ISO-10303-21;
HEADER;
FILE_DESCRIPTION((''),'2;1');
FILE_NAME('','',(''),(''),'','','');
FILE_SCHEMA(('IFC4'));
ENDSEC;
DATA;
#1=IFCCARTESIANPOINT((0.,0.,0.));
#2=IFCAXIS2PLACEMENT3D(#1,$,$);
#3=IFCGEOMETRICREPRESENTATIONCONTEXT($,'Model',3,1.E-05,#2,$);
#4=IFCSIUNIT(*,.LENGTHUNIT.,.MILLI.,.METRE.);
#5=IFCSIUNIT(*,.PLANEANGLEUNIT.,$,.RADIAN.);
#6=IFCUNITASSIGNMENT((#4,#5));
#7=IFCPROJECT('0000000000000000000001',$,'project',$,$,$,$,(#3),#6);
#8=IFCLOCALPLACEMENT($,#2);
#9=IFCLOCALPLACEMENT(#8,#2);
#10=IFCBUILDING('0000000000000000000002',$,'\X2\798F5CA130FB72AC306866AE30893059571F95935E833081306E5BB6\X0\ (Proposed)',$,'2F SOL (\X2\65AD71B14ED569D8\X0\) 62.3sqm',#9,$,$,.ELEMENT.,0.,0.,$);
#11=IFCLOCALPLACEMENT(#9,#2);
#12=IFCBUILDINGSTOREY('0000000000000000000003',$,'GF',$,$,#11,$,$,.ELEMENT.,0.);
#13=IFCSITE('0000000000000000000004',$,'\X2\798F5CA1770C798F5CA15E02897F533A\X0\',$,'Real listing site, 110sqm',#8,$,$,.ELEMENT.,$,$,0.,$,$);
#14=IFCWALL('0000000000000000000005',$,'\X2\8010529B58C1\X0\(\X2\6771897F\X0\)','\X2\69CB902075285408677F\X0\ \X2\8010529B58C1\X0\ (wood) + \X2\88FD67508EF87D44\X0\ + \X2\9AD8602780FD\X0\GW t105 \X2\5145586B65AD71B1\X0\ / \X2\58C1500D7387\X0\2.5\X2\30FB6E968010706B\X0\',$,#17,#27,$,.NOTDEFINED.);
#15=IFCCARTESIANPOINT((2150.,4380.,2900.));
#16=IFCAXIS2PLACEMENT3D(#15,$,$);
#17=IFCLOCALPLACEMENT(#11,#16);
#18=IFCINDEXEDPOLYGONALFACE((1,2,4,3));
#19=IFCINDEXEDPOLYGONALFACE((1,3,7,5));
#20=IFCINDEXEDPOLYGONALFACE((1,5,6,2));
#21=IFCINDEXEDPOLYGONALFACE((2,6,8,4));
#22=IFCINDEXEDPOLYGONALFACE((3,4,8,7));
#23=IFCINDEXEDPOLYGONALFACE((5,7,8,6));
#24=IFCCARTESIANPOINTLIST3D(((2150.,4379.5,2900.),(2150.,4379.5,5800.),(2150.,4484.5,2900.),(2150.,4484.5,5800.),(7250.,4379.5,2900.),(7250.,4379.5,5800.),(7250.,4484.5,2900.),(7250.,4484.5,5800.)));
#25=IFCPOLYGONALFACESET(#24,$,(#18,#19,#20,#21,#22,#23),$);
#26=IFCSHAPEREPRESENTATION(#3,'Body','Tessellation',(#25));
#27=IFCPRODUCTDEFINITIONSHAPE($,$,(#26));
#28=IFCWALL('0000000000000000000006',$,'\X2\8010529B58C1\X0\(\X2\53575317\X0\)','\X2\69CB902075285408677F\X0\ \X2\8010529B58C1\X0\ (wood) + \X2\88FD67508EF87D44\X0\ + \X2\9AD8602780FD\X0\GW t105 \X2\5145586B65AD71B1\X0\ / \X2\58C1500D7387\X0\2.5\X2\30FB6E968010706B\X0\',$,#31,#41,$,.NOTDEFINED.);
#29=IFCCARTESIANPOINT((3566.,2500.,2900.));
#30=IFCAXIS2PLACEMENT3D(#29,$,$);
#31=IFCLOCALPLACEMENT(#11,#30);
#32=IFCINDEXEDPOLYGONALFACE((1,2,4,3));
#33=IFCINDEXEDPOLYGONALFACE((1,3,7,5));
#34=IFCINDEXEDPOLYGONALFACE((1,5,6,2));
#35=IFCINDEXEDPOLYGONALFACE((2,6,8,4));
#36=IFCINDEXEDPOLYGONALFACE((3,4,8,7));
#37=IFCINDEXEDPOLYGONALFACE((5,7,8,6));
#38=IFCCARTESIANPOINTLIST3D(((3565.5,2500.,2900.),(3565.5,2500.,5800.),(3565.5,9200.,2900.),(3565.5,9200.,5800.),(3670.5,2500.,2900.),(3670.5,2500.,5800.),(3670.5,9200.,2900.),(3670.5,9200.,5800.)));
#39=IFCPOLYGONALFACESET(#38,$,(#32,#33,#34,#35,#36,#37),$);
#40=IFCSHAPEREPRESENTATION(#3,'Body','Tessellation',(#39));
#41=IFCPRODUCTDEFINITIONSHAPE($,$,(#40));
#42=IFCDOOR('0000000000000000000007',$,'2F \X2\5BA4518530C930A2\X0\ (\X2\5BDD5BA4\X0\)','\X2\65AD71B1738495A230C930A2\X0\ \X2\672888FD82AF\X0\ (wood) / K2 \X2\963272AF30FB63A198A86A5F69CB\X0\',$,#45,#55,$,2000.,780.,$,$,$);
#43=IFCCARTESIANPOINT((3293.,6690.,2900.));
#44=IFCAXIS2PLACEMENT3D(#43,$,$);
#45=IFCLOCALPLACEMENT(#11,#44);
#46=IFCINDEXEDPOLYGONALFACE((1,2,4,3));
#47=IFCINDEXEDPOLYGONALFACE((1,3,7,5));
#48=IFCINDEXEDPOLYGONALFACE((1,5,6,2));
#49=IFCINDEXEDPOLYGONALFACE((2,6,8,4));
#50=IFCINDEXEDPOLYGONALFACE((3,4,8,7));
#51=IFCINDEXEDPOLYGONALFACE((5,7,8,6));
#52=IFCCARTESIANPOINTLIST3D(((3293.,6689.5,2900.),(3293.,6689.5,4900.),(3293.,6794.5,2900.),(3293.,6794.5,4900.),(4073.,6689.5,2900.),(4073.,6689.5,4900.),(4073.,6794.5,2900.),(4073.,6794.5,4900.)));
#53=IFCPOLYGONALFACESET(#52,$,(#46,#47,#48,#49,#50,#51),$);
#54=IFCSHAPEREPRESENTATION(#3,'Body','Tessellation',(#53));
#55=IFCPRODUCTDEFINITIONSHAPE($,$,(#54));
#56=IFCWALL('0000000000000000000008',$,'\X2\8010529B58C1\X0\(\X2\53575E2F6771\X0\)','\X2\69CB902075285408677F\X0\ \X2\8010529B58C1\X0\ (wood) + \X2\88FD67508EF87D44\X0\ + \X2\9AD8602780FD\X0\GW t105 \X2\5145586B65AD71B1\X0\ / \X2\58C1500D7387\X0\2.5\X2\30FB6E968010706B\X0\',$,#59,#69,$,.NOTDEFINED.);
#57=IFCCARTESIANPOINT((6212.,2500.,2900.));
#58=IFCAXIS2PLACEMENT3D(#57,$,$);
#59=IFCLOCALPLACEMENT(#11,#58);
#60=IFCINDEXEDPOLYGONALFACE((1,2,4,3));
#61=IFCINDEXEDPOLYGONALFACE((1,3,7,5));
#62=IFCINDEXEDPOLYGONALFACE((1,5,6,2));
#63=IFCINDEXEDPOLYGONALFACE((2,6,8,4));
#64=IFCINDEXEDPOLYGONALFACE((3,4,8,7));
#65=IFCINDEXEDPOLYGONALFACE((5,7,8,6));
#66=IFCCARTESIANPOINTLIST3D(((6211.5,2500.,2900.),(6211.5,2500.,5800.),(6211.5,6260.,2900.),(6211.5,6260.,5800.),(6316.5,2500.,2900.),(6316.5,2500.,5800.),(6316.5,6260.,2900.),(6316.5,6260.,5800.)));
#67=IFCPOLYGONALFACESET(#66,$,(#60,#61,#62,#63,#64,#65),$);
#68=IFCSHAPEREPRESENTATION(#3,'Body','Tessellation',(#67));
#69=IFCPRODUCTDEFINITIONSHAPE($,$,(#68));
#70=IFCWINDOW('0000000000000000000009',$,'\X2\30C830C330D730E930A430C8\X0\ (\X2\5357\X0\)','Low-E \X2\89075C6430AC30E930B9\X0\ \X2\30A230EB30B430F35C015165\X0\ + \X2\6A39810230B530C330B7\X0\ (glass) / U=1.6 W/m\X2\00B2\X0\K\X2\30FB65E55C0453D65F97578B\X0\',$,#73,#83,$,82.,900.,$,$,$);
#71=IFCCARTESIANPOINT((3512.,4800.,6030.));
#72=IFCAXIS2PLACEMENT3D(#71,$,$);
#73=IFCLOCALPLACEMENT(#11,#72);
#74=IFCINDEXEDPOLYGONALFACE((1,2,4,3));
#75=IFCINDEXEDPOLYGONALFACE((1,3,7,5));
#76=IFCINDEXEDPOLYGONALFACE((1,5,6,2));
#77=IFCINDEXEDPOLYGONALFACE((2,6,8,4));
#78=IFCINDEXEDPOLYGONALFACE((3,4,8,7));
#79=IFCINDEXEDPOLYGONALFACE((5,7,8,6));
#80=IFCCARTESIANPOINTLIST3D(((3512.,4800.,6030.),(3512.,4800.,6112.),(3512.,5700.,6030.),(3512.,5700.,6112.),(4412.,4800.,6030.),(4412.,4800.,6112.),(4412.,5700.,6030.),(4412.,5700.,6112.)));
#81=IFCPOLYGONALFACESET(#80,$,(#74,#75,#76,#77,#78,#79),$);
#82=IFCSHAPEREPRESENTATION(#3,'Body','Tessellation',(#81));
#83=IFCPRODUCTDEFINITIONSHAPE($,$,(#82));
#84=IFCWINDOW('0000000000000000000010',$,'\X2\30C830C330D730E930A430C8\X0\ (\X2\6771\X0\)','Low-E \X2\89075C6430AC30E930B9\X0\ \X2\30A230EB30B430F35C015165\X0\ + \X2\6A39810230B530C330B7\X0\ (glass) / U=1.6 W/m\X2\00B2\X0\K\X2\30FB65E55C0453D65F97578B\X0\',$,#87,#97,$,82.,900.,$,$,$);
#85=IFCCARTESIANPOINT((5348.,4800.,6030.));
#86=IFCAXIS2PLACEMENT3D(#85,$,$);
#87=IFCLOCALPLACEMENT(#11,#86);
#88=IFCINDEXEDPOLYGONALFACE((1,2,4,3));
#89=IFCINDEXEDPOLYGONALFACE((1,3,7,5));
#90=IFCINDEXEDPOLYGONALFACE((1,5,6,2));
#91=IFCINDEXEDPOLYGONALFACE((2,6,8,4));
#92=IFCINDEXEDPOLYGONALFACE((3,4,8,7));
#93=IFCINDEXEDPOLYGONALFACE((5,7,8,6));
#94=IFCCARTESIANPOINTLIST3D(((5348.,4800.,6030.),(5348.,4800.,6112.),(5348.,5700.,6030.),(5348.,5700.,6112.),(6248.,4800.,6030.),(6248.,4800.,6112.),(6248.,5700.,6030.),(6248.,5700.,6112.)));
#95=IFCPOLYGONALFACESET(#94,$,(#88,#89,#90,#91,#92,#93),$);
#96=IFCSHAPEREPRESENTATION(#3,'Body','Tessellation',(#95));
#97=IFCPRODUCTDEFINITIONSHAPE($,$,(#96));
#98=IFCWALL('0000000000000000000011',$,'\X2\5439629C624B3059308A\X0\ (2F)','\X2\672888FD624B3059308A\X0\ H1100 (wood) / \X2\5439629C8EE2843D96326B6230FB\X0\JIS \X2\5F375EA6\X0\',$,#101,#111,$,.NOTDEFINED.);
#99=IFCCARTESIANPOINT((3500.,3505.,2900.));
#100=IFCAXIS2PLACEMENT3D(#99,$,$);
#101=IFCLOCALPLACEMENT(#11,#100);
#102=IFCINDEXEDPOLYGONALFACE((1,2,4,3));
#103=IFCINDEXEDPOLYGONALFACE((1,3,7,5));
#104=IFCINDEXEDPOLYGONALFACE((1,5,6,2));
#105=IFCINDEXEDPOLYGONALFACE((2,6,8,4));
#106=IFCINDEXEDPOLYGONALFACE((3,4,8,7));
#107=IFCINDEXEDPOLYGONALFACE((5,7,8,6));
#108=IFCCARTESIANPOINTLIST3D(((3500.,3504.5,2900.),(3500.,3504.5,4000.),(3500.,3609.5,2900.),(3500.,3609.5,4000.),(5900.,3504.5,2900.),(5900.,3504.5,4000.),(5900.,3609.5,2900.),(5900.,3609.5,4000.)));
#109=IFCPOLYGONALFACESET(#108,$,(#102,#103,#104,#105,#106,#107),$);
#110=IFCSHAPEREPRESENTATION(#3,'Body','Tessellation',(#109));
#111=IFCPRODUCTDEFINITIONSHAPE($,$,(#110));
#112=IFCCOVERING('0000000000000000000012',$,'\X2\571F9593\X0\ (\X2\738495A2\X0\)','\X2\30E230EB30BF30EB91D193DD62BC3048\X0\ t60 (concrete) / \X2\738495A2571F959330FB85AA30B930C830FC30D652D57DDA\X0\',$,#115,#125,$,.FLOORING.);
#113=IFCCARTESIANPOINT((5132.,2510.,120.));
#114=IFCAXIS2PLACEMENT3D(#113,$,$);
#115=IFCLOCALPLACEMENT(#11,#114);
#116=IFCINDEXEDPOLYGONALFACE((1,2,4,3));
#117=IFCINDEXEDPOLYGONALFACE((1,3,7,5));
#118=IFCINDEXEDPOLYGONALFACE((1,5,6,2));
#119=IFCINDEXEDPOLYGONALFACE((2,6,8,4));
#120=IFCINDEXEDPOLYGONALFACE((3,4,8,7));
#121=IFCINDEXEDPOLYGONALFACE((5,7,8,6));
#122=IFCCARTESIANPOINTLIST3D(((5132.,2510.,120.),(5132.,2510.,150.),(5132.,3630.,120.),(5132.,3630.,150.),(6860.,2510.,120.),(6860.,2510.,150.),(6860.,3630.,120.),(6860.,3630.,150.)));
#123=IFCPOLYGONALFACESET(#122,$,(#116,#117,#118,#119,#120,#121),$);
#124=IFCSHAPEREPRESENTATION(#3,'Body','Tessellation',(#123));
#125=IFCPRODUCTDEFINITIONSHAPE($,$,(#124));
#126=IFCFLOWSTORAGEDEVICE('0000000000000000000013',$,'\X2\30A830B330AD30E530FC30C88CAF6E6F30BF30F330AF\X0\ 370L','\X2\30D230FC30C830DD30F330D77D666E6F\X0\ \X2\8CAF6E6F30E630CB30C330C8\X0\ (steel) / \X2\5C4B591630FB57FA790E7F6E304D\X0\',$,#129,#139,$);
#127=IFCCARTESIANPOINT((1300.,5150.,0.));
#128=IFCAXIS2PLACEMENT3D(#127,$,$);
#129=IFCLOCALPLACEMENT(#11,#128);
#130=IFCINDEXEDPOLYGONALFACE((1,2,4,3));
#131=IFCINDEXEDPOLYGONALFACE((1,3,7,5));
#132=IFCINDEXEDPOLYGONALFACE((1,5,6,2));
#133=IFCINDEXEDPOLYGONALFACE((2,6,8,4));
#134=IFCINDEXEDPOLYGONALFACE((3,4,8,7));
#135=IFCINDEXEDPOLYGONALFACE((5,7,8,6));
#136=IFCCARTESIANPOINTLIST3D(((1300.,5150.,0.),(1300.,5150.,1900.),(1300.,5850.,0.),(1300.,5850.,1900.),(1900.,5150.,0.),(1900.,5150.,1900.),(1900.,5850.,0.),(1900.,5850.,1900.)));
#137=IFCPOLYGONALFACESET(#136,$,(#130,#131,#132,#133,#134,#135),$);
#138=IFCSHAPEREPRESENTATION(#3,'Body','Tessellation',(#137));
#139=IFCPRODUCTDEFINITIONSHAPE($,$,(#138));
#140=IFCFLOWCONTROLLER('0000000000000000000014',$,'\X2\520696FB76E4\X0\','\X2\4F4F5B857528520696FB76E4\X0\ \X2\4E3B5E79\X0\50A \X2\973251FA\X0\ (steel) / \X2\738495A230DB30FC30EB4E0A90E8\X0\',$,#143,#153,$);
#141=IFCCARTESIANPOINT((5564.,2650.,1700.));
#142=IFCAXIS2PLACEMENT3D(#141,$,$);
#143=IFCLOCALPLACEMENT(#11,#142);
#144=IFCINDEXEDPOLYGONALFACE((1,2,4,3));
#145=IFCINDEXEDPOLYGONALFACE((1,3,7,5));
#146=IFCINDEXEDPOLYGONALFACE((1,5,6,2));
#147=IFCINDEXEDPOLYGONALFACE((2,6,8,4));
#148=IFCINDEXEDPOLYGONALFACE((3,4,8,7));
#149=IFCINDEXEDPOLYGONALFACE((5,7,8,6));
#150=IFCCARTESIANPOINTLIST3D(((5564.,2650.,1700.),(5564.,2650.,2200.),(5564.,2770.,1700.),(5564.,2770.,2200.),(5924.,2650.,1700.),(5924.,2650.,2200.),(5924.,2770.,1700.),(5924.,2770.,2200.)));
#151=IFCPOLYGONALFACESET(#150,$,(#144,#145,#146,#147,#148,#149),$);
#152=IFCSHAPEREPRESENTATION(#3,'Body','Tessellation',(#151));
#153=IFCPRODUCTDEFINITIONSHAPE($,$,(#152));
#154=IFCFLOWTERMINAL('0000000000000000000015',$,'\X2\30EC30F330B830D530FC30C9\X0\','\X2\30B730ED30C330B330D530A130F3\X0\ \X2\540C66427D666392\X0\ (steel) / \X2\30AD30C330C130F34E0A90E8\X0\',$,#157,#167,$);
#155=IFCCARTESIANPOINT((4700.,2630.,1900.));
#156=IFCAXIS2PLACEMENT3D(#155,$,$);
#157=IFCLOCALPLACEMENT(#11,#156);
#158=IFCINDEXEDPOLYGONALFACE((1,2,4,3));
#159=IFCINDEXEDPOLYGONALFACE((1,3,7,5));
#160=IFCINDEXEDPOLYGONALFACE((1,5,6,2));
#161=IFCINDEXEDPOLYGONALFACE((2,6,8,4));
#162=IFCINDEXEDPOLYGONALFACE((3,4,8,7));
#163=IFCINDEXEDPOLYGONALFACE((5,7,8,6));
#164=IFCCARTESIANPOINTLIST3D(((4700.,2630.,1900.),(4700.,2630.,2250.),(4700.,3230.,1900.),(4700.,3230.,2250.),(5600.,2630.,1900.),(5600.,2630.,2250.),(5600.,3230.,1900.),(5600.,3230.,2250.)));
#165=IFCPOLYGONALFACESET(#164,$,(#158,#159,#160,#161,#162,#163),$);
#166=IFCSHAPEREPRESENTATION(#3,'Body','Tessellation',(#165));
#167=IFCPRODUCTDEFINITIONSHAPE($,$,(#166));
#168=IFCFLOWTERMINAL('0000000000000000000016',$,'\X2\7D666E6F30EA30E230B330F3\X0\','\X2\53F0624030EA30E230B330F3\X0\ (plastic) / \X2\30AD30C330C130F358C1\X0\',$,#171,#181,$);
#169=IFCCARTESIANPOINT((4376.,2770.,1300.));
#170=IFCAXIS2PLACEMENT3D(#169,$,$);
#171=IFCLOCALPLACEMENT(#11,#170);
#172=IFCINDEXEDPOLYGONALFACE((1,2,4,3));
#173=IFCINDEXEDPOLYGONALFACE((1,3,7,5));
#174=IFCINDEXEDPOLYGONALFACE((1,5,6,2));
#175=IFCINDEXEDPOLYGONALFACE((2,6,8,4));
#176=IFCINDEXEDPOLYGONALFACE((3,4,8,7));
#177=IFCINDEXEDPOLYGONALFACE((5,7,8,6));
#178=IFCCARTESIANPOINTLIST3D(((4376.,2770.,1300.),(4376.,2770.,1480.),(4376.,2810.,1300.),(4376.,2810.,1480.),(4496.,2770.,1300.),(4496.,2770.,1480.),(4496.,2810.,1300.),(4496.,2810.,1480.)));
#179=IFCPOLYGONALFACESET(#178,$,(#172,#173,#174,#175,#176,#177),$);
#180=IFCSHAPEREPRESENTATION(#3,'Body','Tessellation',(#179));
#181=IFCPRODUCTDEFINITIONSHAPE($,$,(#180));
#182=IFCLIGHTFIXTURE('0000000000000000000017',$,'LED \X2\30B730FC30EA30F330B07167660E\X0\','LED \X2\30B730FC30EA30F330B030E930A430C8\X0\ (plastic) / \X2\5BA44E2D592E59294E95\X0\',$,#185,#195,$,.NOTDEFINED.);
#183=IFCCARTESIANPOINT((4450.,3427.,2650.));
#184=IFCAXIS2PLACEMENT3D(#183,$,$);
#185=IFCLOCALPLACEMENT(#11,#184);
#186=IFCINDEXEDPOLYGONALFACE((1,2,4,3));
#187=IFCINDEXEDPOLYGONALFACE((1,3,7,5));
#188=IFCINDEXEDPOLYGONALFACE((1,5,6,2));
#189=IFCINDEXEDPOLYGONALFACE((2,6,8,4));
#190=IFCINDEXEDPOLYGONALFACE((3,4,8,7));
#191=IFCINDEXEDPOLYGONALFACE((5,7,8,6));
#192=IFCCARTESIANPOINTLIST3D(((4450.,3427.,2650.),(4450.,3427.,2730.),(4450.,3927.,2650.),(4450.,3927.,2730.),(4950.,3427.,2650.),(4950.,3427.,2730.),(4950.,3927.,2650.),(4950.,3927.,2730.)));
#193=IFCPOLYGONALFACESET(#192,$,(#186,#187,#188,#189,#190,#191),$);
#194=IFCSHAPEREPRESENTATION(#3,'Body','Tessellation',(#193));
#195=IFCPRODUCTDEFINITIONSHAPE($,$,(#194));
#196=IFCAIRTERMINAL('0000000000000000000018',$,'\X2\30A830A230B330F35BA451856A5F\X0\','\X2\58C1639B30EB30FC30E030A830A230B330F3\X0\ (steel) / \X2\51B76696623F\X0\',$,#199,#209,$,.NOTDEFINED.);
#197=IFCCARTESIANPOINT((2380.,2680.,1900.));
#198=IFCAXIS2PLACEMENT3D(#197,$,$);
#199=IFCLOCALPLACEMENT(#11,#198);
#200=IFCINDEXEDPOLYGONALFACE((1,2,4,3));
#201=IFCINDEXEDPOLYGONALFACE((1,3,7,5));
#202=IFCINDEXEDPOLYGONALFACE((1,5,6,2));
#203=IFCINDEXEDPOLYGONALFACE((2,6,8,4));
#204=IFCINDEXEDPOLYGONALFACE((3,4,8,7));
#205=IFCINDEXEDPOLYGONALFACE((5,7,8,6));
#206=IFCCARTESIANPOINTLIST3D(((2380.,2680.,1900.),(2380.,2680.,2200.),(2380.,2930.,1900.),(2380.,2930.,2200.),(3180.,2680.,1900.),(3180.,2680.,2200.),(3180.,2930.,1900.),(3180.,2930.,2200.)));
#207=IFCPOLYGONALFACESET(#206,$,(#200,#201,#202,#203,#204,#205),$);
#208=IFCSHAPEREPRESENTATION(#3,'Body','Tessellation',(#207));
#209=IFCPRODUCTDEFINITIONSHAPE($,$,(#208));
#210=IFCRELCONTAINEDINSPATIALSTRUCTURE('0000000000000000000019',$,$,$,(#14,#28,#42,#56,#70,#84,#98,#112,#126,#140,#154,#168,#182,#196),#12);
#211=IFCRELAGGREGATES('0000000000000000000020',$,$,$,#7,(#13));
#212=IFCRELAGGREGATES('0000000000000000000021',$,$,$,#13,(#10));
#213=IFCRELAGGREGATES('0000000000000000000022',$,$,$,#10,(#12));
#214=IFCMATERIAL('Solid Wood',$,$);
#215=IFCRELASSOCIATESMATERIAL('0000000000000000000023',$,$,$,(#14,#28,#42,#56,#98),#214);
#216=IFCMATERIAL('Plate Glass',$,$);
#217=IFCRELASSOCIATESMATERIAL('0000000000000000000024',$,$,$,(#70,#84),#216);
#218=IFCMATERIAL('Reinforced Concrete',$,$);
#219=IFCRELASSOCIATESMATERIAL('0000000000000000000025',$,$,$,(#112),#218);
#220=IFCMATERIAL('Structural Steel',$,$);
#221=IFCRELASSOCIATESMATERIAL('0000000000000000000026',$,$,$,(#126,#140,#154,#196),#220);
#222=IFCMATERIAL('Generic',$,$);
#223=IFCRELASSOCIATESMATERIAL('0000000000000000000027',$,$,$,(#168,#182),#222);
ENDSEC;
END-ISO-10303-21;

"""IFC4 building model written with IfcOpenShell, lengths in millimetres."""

from ifc_helpers import new_model, si_unit, frame, frame_2d, origin, place, context, project, spatial, rectangle, extrude, material, element, fill, save


model = new_model("IFC4")

# Units and contexts
model_context = context("Model", 3, precision=1e-05, world=origin())
ifc_project = project(units=[si_unit("LENGTHUNIT", "METRE", prefix="MILLI"), si_unit("PLANEANGLEUNIT", "RADIAN")], contexts=[model_context])

# Site, building, storey
site_placement = place(None, origin())
site = spatial("IfcSite", under=ifc_project, at=site_placement, Name="福岡県福岡市西区", ObjectType="Real listing site, 110sqm", CompositionType="ELEMENT", RefElevation=0.0)
building_placement = place(site_placement, origin())
building = spatial("IfcBuilding", under=site, at=building_placement, Name="福岡・犬と暮らす土間広めの家 (Proposed)", ObjectType="2F SOL (断熱仕様) 62.3sqm", CompositionType="ELEMENT", ElevationOfRefHeight=0.0, ElevationOfTerrain=0.0)
storey_placement = place(building_placement, origin())
storey = spatial("IfcBuildingStorey", under=building, at=storey_placement, Name="GF", CompositionType="ELEMENT", Elevation=0.0)

# Shared definitions
ifc_material_1 = material(Name="Solid Wood")

# Wall
wall_1_placement = place(storey_placement, frame((2150.0, 4380.0, 2900.0)))
element("IfcWall", 1, at=wall_1_placement, inside=storey, material=ifc_material_1, Name="耐力壁(東西)", Description="構造用合板 耐力壁 (wood) + 製材軸組 + 高性能GW t105 充填断熱 / 壁倍率2.5・準耐火", PredefinedType="NOTDEFINED", context=model_context, shape_type="SweptSolid", body=[
    extrude(rectangle(XDim=5100.0, YDim=105.0, at=frame_2d((2550.0, 52.0))), frame((2150.0, 4380.0, 2900.0)), (0.0, 0.0, 1.0), 2900.0),
])

# Wall, opening, door
wall_2_placement = place(storey_placement, frame((3566.0, 2500.0, 2900.0)))
wall_2 = element("IfcWall", 2, at=wall_2_placement, inside=storey, material=ifc_material_1, Name="耐力壁(南北)", Description="構造用合板 耐力壁 (wood) + 製材軸組 + 高性能GW t105 充填断熱 / 壁倍率2.5・準耐火", PredefinedType="NOTDEFINED", context=model_context, shape_type="SweptSolid", body=[
    extrude(rectangle(XDim=105.0, YDim=6700.0, at=frame_2d((52.0, 3350.0))), frame((3566.0, 2500.0, 2900.0)), (0.0, 0.0, 1.0), 2900.0),
])
opening_placement = place(storey_placement, frame((3293.0, 6690.0, 2900.0)))
opening = element("IfcOpeningElement", 3, at=opening_placement, cuts=wall_2, PredefinedType="NOTDEFINED", context=model_context, shape_type="SweptSolid", body=[
    extrude(rectangle(XDim=780.0, YDim=105.0, at=frame_2d((390.0, 52.0))), frame((3293.0, 6690.0, 2900.0)), (0.0, 0.0, 1.0), 2000.0),
])
door_placement = place(storey_placement, frame((3293.0, 6690.0, 2900.0)))
door = element("IfcDoor", 4, at=door_placement, inside=storey, material=ifc_material_1, Name="2F 室内ドア (寝室)", Description="断熱玄関ドア 木製芯 (wood) / K2 防犯・採風機構", OverallHeight=2000.0, OverallWidth=780.0, context=model_context, shape_type="SweptSolid", body=[
    extrude(rectangle(XDim=780.0, YDim=105.0, at=frame_2d((390.0, 52.0))), frame((3293.0, 6690.0, 2900.0)), (0.0, 0.0, 1.0), 2000.0),
])
fill(opening, door)

# Wall
wall_3_placement = place(storey_placement, frame((6212.0, 2500.0, 2900.0)))
element("IfcWall", 5, at=wall_3_placement, inside=storey, material=ifc_material_1, Name="耐力壁(南帯東)", Description="構造用合板 耐力壁 (wood) + 製材軸組 + 高性能GW t105 充填断熱 / 壁倍率2.5・準耐火", PredefinedType="NOTDEFINED", context=model_context, shape_type="SweptSolid", body=[
    extrude(rectangle(XDim=105.0, YDim=3760.0, at=frame_2d((52.0, 1880.0))), frame((6212.0, 2500.0, 2900.0)), (0.0, 0.0, 1.0), 2900.0),
])

# Windows
ifc_material_2 = material(Name="Plate Glass")
window_1_placement = place(storey_placement, frame((3512.0, 4800.0, 6030.0)))
element("IfcWindow", 6, at=window_1_placement, inside=storey, material=ifc_material_2, Name="トップライト (南)", Description="Low-E 複層ガラス アルゴン封入 + 樹脂サッシ (glass) / U=1.6 W/m²K・日射取得型", OverallHeight=82.0, OverallWidth=900.0, context=model_context, shape_type="SweptSolid", body=[
    extrude(rectangle(XDim=900.0, YDim=900.0, at=frame_2d((450.0, 450.0))), frame((3512.0, 4800.0, 6030.0)), (0.0, 0.0, 1.0), 82.0),
])
window_2_placement = place(storey_placement, frame((5348.0, 4800.0, 6030.0)))
element("IfcWindow", 7, at=window_2_placement, inside=storey, material=ifc_material_2, Name="トップライト (東)", Description="Low-E 複層ガラス アルゴン封入 + 樹脂サッシ (glass) / U=1.6 W/m²K・日射取得型", OverallHeight=82.0, OverallWidth=900.0, context=model_context, shape_type="SweptSolid", body=[
    extrude(rectangle(XDim=900.0, YDim=900.0, at=frame_2d((450.0, 450.0))), frame((5348.0, 4800.0, 6030.0)), (0.0, 0.0, 1.0), 82.0),
])

# Wall
wall_4_placement = place(storey_placement, frame((3500.0, 3505.0, 2900.0)))
element("IfcWall", 8, at=wall_4_placement, inside=storey, material=ifc_material_1, Name="吹抜手すり (2F)", Description="木製手すり H1100 (wood) / 吹抜転落防止・JIS 強度", PredefinedType="NOTDEFINED", context=model_context, shape_type="SweptSolid", body=[
    extrude(rectangle(XDim=2400.0, YDim=105.0, at=frame_2d((1200.0, 52.0))), frame((3500.0, 3505.0, 2900.0)), (0.0, 0.0, 1.0), 1100.0),
])

# Covering
ifc_material_3 = material(Name="Reinforced Concrete")
covering_placement = place(storey_placement, frame((5132.0, 2510.0, 120.0)))
element("IfcCovering", 9, at=covering_placement, inside=storey, material=ifc_material_3, Name="土間 (玄関)", Description="モルタル金鏝押え t60 (concrete) / 玄関土間・薪ストーブ動線", PredefinedType="FLOORING", context=model_context, shape_type="SweptSolid", body=[
    extrude(rectangle(XDim=1728.0, YDim=1120.0, at=frame_2d((864.0, 560.0))), frame((5132.0, 2510.0, 120.0)), (0.0, 0.0, 1.0), 30.0),
])

# Flow storage device
ifc_material_4 = material(Name="Structural Steel")
flow_storage_device_placement = place(storey_placement, frame((1300.0, 5150.0, 0.0)))
element("IfcFlowStorageDevice", 10, at=flow_storage_device_placement, inside=storey, material=ifc_material_4, Name="エコキュート貯湯タンク 370L", Description="ヒートポンプ給湯 貯湯ユニット (steel) / 屋外・基礎置き", context=model_context, shape_type="SweptSolid", body=[
    extrude(rectangle(XDim=600.0, YDim=700.0, at=frame_2d((300.0, 350.0))), frame((1300.0, 5150.0, 0.0)), (0.0, 0.0, 1.0), 1900.0),
])

# Flow controller
flow_controller_placement = place(storey_placement, frame((5564.0, 2650.0, 1700.0)))
element("IfcFlowController", 11, at=flow_controller_placement, inside=storey, material=ifc_material_4, Name="分電盤", Description="住宅用分電盤 主幹50A 露出 (steel) / 玄関ホール上部", context=model_context, shape_type="SweptSolid", body=[
    extrude(rectangle(XDim=360.0, YDim=120.0, at=frame_2d((180.0, 60.0))), frame((5564.0, 2650.0, 1700.0)), (0.0, 0.0, 1.0), 500.0),
])

# Flow terminals
flow_terminal_1_placement = place(storey_placement, frame((4700.0, 2630.0, 1900.0)))
element("IfcFlowTerminal", 12, at=flow_terminal_1_placement, inside=storey, material=ifc_material_4, Name="レンジフード", Description="シロッコファン 同時給排 (steel) / キッチン上部", context=model_context, shape_type="SweptSolid", body=[
    extrude(rectangle(XDim=900.0, YDim=600.0, at=frame_2d((450.0, 300.0))), frame((4700.0, 2630.0, 1900.0)), (0.0, 0.0, 1.0), 350.0),
])
ifc_material_5 = material(Name="Generic")
flow_terminal_2_placement = place(storey_placement, frame((4376.0, 2770.0, 1300.0)))
element("IfcFlowTerminal", 13, at=flow_terminal_2_placement, inside=storey, material=ifc_material_5, Name="給湯リモコン", Description="台所リモコン (plastic) / キッチン壁", context=model_context, shape_type="SweptSolid", body=[
    extrude(rectangle(XDim=120.0, YDim=40.0, at=frame_2d((60.0, 20.0))), frame((4376.0, 2770.0, 1300.0)), (0.0, 0.0, 1.0), 180.0),
])

# Light fixture
light_fixture_1_placement = place(storey_placement, frame((4450.0, 3427.0, 2650.0)))
element("IfcLightFixture", 14, at=light_fixture_1_placement, inside=storey, material=ifc_material_5, Name="LED シーリング照明", Description="LED シーリングライト (plastic) / 室中央天井", PredefinedType="NOTDEFINED", context=model_context, shape_type="SweptSolid", body=[
    extrude(rectangle(XDim=500.0, YDim=500.0, at=frame_2d((250.0, 250.0))), frame((4450.0, 3427.0, 2650.0)), (0.0, 0.0, 1.0), 80.0),
])

# Air terminal
air_terminal_1_placement = place(storey_placement, frame((2380.0, 2680.0, 1900.0)))
element("IfcAirTerminal", 15, at=air_terminal_1_placement, inside=storey, material=ifc_material_4, Name="エアコン室内機", Description="壁掛ルームエアコン (steel) / 冷暖房", PredefinedType="NOTDEFINED", context=model_context, shape_type="SweptSolid", body=[
    extrude(rectangle(XDim=800.0, YDim=250.0, at=frame_2d((400.0, 125.0))), frame((2380.0, 2680.0, 1900.0)), (0.0, 0.0, 1.0), 300.0),
])

save(model, "model.ifc")
